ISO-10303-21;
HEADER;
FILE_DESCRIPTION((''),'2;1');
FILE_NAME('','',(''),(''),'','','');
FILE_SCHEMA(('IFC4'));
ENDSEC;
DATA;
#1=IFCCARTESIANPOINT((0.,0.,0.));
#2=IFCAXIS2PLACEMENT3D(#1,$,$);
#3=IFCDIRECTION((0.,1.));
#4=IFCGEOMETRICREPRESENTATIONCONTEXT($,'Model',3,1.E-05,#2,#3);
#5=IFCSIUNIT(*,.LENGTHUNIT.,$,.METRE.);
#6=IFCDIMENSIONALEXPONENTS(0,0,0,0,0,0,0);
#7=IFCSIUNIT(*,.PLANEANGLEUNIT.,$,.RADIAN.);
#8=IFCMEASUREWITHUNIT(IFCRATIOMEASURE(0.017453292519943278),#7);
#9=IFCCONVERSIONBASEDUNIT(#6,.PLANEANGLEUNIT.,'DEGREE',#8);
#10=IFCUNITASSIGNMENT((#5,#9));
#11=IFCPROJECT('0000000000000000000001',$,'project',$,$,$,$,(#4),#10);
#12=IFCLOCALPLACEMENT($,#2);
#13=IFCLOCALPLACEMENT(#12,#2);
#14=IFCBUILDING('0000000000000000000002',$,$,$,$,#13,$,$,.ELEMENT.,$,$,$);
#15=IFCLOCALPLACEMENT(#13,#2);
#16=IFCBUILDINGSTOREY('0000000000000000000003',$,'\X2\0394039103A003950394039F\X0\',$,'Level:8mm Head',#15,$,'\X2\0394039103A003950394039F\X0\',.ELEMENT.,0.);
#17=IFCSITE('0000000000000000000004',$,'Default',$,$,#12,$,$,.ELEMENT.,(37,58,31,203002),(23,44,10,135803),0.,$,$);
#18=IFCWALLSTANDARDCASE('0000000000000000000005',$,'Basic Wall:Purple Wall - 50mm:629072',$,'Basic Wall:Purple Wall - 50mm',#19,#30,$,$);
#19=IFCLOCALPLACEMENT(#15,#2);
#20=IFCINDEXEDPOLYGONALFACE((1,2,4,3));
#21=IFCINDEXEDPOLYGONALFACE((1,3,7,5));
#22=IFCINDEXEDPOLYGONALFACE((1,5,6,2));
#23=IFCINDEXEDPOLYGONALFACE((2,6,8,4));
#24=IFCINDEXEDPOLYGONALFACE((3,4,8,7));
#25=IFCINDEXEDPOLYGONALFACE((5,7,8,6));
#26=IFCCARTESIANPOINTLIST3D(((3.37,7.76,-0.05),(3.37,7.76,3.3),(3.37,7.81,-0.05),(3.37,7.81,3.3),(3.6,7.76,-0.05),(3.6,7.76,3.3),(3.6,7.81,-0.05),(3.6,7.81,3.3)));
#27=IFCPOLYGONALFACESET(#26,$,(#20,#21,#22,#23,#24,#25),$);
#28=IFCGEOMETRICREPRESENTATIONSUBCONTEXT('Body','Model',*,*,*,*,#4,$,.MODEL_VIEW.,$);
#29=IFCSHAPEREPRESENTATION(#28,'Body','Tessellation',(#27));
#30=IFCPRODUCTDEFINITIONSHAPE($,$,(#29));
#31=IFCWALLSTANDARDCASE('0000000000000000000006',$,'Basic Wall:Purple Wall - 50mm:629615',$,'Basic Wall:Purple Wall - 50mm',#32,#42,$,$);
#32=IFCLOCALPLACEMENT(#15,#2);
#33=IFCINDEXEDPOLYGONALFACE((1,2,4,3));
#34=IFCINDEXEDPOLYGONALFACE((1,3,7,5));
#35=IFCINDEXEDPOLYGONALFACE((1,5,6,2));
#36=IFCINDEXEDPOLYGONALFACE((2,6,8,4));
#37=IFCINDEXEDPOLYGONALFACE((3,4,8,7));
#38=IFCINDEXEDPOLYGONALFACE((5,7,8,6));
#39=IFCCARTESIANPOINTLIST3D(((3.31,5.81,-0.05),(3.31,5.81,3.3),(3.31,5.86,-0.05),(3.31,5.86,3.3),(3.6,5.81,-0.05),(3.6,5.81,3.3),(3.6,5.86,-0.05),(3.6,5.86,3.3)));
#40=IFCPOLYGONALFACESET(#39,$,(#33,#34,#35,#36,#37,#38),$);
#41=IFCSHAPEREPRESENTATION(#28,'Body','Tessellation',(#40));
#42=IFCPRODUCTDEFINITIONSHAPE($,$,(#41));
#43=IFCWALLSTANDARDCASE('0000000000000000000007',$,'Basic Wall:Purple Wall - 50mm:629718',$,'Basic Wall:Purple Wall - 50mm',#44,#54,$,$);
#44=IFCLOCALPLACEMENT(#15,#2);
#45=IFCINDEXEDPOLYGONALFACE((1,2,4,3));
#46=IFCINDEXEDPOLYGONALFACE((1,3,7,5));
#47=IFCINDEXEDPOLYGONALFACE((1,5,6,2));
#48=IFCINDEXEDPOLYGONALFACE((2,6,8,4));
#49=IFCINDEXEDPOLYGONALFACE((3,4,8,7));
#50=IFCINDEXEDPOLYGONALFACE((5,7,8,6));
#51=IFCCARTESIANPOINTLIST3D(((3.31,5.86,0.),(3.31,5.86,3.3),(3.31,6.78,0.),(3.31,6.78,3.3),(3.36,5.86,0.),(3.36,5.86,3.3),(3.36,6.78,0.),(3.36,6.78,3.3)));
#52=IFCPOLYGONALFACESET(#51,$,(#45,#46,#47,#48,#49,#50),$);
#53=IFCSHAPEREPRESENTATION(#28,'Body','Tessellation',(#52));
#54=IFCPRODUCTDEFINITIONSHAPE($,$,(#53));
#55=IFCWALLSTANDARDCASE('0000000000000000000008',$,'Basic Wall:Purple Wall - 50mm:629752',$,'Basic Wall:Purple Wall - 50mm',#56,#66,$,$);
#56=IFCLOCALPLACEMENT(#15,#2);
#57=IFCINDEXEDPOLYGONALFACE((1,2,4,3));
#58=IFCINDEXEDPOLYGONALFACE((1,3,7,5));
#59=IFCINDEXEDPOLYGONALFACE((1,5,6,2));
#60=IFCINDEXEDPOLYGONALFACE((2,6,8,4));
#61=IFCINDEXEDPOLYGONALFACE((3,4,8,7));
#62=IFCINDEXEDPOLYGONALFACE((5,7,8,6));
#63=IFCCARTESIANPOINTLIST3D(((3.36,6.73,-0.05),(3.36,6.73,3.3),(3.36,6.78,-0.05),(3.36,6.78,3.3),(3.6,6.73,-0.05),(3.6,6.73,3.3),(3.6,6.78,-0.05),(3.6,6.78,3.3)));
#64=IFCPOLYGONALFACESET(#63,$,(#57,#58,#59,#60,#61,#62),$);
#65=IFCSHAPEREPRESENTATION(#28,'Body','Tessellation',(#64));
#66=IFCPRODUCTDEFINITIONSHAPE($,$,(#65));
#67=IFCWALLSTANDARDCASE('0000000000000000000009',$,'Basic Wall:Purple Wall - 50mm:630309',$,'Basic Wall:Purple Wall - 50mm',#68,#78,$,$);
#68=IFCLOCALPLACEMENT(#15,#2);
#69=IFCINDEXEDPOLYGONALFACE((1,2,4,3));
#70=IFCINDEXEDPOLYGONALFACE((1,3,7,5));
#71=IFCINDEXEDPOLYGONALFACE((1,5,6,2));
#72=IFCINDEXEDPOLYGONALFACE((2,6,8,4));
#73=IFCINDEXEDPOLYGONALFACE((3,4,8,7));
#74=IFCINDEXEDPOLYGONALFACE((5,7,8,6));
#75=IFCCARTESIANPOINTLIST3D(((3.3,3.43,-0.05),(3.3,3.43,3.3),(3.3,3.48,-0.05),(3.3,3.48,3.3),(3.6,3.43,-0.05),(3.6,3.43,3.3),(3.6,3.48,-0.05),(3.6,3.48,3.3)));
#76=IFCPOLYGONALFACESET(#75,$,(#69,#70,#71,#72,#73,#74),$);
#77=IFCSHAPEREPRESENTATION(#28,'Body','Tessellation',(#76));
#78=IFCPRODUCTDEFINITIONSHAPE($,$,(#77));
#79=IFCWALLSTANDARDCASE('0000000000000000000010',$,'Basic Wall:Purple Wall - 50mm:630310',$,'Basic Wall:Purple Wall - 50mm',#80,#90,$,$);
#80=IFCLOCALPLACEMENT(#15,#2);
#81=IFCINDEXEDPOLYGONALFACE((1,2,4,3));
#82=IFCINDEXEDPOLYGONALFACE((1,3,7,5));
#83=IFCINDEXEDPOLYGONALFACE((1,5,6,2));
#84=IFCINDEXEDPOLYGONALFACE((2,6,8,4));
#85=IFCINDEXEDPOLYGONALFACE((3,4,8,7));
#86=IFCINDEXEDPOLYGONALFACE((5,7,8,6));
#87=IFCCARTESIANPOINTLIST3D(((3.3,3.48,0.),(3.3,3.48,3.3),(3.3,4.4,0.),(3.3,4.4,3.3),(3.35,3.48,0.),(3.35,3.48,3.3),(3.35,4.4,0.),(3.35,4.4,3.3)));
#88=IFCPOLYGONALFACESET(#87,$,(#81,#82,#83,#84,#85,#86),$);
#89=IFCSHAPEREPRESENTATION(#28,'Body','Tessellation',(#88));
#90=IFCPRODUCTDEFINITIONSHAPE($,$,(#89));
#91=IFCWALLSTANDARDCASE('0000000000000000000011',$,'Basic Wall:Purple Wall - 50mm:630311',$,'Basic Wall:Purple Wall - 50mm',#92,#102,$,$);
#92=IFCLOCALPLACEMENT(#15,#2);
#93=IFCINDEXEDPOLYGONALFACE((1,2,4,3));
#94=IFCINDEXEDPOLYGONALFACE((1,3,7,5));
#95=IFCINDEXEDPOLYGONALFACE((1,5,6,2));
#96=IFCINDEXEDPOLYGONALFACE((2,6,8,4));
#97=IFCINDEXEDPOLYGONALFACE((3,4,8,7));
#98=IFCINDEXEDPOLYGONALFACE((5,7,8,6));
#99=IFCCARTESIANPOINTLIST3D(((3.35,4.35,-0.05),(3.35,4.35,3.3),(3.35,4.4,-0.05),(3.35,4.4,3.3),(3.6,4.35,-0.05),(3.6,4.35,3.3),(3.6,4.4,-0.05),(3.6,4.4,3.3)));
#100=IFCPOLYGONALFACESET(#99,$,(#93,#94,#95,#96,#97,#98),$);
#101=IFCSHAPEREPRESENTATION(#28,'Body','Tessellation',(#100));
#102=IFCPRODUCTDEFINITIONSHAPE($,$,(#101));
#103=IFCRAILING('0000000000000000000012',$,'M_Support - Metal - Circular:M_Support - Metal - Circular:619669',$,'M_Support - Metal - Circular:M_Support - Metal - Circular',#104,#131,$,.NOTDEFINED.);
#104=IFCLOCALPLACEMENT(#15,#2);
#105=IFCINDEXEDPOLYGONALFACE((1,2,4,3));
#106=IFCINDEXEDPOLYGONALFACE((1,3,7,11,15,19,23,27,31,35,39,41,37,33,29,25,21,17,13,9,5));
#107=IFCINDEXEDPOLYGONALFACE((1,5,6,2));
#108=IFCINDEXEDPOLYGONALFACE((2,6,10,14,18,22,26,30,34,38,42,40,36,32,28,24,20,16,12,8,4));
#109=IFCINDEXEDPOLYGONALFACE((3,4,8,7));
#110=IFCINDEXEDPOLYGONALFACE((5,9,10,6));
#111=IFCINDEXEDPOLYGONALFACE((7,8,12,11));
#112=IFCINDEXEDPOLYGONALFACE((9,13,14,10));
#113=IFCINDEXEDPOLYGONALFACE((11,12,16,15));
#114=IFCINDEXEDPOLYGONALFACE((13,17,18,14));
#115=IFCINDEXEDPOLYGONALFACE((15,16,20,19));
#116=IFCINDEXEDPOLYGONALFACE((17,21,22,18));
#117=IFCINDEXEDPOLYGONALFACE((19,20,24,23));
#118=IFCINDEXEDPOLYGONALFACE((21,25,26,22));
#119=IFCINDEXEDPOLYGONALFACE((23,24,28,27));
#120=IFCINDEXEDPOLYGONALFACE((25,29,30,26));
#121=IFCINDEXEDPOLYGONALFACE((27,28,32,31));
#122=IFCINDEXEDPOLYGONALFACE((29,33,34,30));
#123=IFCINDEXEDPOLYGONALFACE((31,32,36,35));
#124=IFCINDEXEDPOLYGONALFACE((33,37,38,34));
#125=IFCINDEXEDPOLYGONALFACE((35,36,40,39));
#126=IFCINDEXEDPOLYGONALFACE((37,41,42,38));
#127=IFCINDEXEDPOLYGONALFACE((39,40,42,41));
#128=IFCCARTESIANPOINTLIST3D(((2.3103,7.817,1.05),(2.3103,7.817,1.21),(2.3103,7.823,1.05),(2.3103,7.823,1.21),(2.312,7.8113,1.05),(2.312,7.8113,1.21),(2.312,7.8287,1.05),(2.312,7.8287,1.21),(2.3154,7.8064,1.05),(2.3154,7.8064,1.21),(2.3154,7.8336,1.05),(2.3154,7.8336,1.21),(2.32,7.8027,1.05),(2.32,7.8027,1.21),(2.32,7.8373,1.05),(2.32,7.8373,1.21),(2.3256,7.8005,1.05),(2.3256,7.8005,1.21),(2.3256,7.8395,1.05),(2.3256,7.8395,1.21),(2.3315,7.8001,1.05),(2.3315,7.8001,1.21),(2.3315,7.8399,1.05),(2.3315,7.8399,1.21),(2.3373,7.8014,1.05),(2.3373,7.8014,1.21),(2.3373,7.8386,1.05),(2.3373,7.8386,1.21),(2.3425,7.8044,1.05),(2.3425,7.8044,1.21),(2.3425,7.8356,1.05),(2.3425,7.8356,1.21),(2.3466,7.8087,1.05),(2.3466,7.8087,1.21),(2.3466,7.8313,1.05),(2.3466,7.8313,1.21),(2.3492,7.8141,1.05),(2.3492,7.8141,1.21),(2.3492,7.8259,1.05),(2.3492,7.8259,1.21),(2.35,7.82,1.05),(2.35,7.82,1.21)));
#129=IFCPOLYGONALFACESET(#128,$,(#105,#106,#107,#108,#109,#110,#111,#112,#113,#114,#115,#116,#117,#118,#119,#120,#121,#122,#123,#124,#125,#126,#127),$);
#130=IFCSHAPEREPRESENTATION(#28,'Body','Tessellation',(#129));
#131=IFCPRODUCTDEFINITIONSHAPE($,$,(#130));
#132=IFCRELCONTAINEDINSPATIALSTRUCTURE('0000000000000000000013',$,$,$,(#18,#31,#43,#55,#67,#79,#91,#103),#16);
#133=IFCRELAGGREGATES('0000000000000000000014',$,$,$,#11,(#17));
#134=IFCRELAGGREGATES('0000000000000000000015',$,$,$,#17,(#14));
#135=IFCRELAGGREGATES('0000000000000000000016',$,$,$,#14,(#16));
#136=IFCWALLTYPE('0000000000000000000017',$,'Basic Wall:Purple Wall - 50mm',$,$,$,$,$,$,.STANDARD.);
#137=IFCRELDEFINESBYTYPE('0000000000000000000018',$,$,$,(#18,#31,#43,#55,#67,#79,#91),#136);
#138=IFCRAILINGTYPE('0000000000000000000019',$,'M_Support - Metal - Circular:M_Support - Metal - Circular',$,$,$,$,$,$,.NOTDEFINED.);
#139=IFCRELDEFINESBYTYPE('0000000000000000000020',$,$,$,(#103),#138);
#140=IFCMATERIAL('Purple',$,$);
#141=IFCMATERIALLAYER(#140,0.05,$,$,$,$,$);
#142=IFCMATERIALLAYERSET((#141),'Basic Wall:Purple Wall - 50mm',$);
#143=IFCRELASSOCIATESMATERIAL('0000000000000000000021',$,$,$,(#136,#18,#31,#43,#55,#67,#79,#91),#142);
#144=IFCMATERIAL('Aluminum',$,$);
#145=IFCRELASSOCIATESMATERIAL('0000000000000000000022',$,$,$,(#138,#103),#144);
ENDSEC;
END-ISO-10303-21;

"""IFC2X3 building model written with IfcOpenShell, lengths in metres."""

from ifc_helpers import new_model, entity, si_unit, converted_unit, direction, frame, frame_2d, origin, place, context, subcontext, project, spatial, polyline, rectangle, circle, extrude, clip, bounded_halfspace, source, transform, mapped, material, layer, layer_set, layer_usage, type_object, type_shapes, element, save


model = new_model("IFC2X3")

# Units and contexts
model_context = context("Model", 3, precision=1e-05, world=origin(), true_north=direction((0.0, 1.0)))
body_context = subcontext(model_context, "Body", "Model", "MODEL_VIEW")
ifc_project = project(units=[si_unit("LENGTHUNIT", "METRE"), converted_unit("PLANEANGLEUNIT", "DEGREE", entity("IfcRatioMeasure", 0.017453292519943278), si_unit("PLANEANGLEUNIT", "RADIAN"), dimensions=[0, 0, 0, 0, 0, 0, 0])], contexts=[model_context])

# Site, building, storey
site_placement = place(None, origin())
site = spatial("IfcSite", under=ifc_project, at=site_placement, Name="Default", CompositionType="ELEMENT", RefLatitude=(37, 58, 31, 203002), RefLongitude=(23, 44, 10, 135803), RefElevation=0.0)
building_placement = place(site_placement, origin())
building = spatial("IfcBuilding", under=site, at=building_placement, CompositionType="ELEMENT")
storey_placement = place(building_placement, origin())
storey = spatial("IfcBuildingStorey", under=building, at=storey_placement, Name="ΔΑΠΕΔΟ", ObjectType="Level:8mm Head", LongName="ΔΑΠΕΔΟ", CompositionType="ELEMENT", Elevation=0.0)

# Walls
ifc_material_1 = material(Name="Purple")
ifc_layer_1 = layer(ifc_material_1, 0.05)
ifc_layer_set_1 = layer_set([ifc_layer_1], Name="Basic Wall:Purple Wall - 50mm")
ifc_layer_usage_1 = layer_usage(ifc_layer_set_1, "AXIS2", "POSITIVE", -0.025)
wall_type_1 = type_object("IfcWallType", Name="Basic Wall:Purple Wall - 50mm", PredefinedType="STANDARD", material=ifc_layer_set_1)
wall_1_placement = place(storey_placement, frame((3.37, 7.785, -0.05)))
element("IfcWallStandardCase", 1, at=wall_1_placement, inside=storey, type_object=wall_type_1, material=ifc_layer_usage_1, Name="Basic Wall:Purple Wall - 50mm:629072", ObjectType="Basic Wall:Purple Wall - 50mm", context=body_context, shape_type="Clipping", body=[
    clip(extrude(rectangle(XDim=0.23, YDim=0.05, at=frame_2d((0.115, 0.0), x_axis=(-1.0, 0.0))), origin(), (0.0, 0.0, 1.0), 3.35), bounded_halfspace(frame((0.23, -0.025, 0.0), z_axis=(0.0, 0.0, 1.0), x_axis=(0.0, 1.0, 0.0)), True, frame((0.23, -0.025, 0.0), z_axis=(0.0, 0.0, 1.0), x_axis=(0.0, 1.0, 0.0)), polyline([(0.0, 0.0), (0.05, 0.0), (0.05, 0.23), (0.04, 0.23), (0.0, 0.23), (0.0, 0.065), (0.0, 0.0)]))),
])
wall_2_placement = place(storey_placement, frame((3.31, 5.835, -0.05)))
element("IfcWallStandardCase", 2, at=wall_2_placement, inside=storey, type_object=wall_type_1, material=ifc_layer_usage_1, Name="Basic Wall:Purple Wall - 50mm:629615", ObjectType="Basic Wall:Purple Wall - 50mm", context=body_context, shape_type="Clipping", body=[
    clip(extrude(rectangle(XDim=0.29, YDim=0.05, at=frame_2d((0.145, 0.0), x_axis=(-1.0, 0.0))), origin(), (0.0, 0.0, 1.0), 3.35), bounded_halfspace(frame((0.29, -0.025, 0.0), z_axis=(0.0, 0.0, 1.0), x_axis=(0.0, 1.0, 0.0)), True, frame((0.29, -0.025, 0.0), z_axis=(0.0, 0.0, 1.0), x_axis=(0.0, 1.0, 0.0)), polyline([(0.0, 0.0), (0.05, 0.0), (0.05, 0.29), (0.0, 0.29), (0.0, 0.065), (0.0, 0.055), (0.0, 0.0)]))),
])
wall_3_placement = place(storey_placement, frame((3.335, 6.78, 0.0), z_axis=(0.0, 0.0, 1.0), x_axis=(0.0, -1.0, 0.0)))
element("IfcWallStandardCase", 3, at=wall_3_placement, inside=storey, type_object=wall_type_1, material=ifc_layer_usage_1, Name="Basic Wall:Purple Wall - 50mm:629718", ObjectType="Basic Wall:Purple Wall - 50mm", context=body_context, shape_type="SweptSolid", body=[
    extrude(rectangle(XDim=0.92, YDim=0.05, at=frame_2d((0.46, 0.0), x_axis=(-1.0, 0.0))), origin(), (0.0, 0.0, 1.0), 3.3),
])
wall_4_placement = place(storey_placement, frame((3.6, 6.755, -0.05), z_axis=(0.0, 0.0, 1.0), x_axis=(-1.0, 0.0, 0.0)))
element("IfcWallStandardCase", 4, at=wall_4_placement, inside=storey, type_object=wall_type_1, material=ifc_layer_usage_1, Name="Basic Wall:Purple Wall - 50mm:629752", ObjectType="Basic Wall:Purple Wall - 50mm", context=body_context, shape_type="Clipping", body=[
    clip(extrude(rectangle(XDim=0.24, YDim=0.05, at=frame_2d((0.12, 0.0), x_axis=(-1.0, 0.0))), origin(), (0.0, 0.0, 1.0), 3.35), bounded_halfspace(frame((0.24, -0.025, 0.0), z_axis=(0.0, 0.0, 1.0), x_axis=(0.0, -1.0, 0.0)), True, frame((0.24, -0.025, 0.0), z_axis=(0.0, 0.0, 1.0), x_axis=(0.0, -1.0, 0.0)), polyline([(0.0, 0.0), (-0.05, 0.0), (-0.05, -0.24), (0.0, -0.24), (0.0, -0.175), (0.0, 0.0)]))),
])
wall_5_placement = place(storey_placement, frame((3.3, 3.455, -0.05)))
element("IfcWallStandardCase", 5, at=wall_5_placement, inside=storey, type_object=wall_type_1, material=ifc_layer_usage_1, Name="Basic Wall:Purple Wall - 50mm:630309", ObjectType="Basic Wall:Purple Wall - 50mm", context=body_context, shape_type="Clipping", body=[
    clip(extrude(rectangle(XDim=0.3, YDim=0.05, at=frame_2d((0.15, 0.0), x_axis=(-1.0, 0.0))), origin(), (0.0, 0.0, 1.0), 3.35), bounded_halfspace(frame((0.3, -0.025, 0.0), z_axis=(0.0, 0.0, 1.0), x_axis=(0.0, 1.0, 0.0)), True, frame((0.3, -0.025, 0.0), z_axis=(0.0, 0.0, 1.0), x_axis=(0.0, 1.0, 0.0)), polyline([(0.0, 0.0), (0.05, 0.0), (0.05, 0.3), (0.0, 0.3), (0.0, 0.01), (0.0, 0.0)]))),
])
wall_6_placement = place(storey_placement, frame((3.325, 4.4, 0.0), z_axis=(0.0, 0.0, 1.0), x_axis=(0.0, -1.0, 0.0)))
element("IfcWallStandardCase", 6, at=wall_6_placement, inside=storey, type_object=wall_type_1, material=ifc_layer_usage_1, Name="Basic Wall:Purple Wall - 50mm:630310", ObjectType="Basic Wall:Purple Wall - 50mm", context=body_context, shape_type="SweptSolid", body=[
    extrude(rectangle(XDim=0.92, YDim=0.05, at=frame_2d((0.46, 0.0), x_axis=(-1.0, 0.0))), origin(), (0.0, 0.0, 1.0), 3.3),
])
wall_7_placement = place(storey_placement, frame((3.6, 4.375, -0.05), z_axis=(0.0, 0.0, 1.0), x_axis=(-1.0, 0.0, 0.0)))
element("IfcWallStandardCase", 7, at=wall_7_placement, inside=storey, type_object=wall_type_1, material=ifc_layer_usage_1, Name="Basic Wall:Purple Wall - 50mm:630311", ObjectType="Basic Wall:Purple Wall - 50mm", context=body_context, shape_type="Clipping", body=[
    clip(extrude(rectangle(XDim=0.25, YDim=0.05, at=frame_2d((0.125, 0.0), x_axis=(-1.0, 0.0))), origin(), (0.0, 0.0, 1.0), 3.35), bounded_halfspace(frame((0.25, -0.025, 0.0), z_axis=(0.0, 0.0, 1.0), x_axis=(0.0, -1.0, 0.0)), True, frame((0.25, -0.025, 0.0), z_axis=(0.0, 0.0, 1.0), x_axis=(0.0, -1.0, 0.0)), polyline([(0.0, 0.0), (-0.05, 0.0), (-0.05, -0.25), (0.0, -0.25), (0.0, -0.195), (0.0, 0.0)]))),
])

# Railing
ifc_material_2 = material(Name="Aluminum")
railing_type = type_object("IfcRailingType", Name="M_Support - Metal - Circular:M_Support - Metal - Circular", PredefinedType="NOTDEFINED", material=ifc_material_2)
shared_shape = source(origin(), body_context, "Body", "SweptSolid", [
    extrude(circle(Radius=0.02, at=frame_2d((0.0, 0.0), x_axis=(1.0, 0.0))), frame((0.0, 0.0, -0.16)), (0.0, 0.0, 1.0), 0.16),
])
type_shapes(railing_type, [shared_shape])
railing_placement = place(storey_placement, frame((2.33, 7.82, 1.21)))
element("IfcRailing", 8, at=railing_placement, inside=storey, type_object=railing_type, material=ifc_material_2, Name="M_Support - Metal - Circular:M_Support - Metal - Circular:619669", ObjectType="M_Support - Metal - Circular:M_Support - Metal - Circular", PredefinedType="NOTDEFINED", context=body_context, shape_type="MappedRepresentation", body=[
    mapped(shared_shape, transform((0.0, 0.0, 0.0), scale=1.0)),
])

save(model, "model.ifc")
